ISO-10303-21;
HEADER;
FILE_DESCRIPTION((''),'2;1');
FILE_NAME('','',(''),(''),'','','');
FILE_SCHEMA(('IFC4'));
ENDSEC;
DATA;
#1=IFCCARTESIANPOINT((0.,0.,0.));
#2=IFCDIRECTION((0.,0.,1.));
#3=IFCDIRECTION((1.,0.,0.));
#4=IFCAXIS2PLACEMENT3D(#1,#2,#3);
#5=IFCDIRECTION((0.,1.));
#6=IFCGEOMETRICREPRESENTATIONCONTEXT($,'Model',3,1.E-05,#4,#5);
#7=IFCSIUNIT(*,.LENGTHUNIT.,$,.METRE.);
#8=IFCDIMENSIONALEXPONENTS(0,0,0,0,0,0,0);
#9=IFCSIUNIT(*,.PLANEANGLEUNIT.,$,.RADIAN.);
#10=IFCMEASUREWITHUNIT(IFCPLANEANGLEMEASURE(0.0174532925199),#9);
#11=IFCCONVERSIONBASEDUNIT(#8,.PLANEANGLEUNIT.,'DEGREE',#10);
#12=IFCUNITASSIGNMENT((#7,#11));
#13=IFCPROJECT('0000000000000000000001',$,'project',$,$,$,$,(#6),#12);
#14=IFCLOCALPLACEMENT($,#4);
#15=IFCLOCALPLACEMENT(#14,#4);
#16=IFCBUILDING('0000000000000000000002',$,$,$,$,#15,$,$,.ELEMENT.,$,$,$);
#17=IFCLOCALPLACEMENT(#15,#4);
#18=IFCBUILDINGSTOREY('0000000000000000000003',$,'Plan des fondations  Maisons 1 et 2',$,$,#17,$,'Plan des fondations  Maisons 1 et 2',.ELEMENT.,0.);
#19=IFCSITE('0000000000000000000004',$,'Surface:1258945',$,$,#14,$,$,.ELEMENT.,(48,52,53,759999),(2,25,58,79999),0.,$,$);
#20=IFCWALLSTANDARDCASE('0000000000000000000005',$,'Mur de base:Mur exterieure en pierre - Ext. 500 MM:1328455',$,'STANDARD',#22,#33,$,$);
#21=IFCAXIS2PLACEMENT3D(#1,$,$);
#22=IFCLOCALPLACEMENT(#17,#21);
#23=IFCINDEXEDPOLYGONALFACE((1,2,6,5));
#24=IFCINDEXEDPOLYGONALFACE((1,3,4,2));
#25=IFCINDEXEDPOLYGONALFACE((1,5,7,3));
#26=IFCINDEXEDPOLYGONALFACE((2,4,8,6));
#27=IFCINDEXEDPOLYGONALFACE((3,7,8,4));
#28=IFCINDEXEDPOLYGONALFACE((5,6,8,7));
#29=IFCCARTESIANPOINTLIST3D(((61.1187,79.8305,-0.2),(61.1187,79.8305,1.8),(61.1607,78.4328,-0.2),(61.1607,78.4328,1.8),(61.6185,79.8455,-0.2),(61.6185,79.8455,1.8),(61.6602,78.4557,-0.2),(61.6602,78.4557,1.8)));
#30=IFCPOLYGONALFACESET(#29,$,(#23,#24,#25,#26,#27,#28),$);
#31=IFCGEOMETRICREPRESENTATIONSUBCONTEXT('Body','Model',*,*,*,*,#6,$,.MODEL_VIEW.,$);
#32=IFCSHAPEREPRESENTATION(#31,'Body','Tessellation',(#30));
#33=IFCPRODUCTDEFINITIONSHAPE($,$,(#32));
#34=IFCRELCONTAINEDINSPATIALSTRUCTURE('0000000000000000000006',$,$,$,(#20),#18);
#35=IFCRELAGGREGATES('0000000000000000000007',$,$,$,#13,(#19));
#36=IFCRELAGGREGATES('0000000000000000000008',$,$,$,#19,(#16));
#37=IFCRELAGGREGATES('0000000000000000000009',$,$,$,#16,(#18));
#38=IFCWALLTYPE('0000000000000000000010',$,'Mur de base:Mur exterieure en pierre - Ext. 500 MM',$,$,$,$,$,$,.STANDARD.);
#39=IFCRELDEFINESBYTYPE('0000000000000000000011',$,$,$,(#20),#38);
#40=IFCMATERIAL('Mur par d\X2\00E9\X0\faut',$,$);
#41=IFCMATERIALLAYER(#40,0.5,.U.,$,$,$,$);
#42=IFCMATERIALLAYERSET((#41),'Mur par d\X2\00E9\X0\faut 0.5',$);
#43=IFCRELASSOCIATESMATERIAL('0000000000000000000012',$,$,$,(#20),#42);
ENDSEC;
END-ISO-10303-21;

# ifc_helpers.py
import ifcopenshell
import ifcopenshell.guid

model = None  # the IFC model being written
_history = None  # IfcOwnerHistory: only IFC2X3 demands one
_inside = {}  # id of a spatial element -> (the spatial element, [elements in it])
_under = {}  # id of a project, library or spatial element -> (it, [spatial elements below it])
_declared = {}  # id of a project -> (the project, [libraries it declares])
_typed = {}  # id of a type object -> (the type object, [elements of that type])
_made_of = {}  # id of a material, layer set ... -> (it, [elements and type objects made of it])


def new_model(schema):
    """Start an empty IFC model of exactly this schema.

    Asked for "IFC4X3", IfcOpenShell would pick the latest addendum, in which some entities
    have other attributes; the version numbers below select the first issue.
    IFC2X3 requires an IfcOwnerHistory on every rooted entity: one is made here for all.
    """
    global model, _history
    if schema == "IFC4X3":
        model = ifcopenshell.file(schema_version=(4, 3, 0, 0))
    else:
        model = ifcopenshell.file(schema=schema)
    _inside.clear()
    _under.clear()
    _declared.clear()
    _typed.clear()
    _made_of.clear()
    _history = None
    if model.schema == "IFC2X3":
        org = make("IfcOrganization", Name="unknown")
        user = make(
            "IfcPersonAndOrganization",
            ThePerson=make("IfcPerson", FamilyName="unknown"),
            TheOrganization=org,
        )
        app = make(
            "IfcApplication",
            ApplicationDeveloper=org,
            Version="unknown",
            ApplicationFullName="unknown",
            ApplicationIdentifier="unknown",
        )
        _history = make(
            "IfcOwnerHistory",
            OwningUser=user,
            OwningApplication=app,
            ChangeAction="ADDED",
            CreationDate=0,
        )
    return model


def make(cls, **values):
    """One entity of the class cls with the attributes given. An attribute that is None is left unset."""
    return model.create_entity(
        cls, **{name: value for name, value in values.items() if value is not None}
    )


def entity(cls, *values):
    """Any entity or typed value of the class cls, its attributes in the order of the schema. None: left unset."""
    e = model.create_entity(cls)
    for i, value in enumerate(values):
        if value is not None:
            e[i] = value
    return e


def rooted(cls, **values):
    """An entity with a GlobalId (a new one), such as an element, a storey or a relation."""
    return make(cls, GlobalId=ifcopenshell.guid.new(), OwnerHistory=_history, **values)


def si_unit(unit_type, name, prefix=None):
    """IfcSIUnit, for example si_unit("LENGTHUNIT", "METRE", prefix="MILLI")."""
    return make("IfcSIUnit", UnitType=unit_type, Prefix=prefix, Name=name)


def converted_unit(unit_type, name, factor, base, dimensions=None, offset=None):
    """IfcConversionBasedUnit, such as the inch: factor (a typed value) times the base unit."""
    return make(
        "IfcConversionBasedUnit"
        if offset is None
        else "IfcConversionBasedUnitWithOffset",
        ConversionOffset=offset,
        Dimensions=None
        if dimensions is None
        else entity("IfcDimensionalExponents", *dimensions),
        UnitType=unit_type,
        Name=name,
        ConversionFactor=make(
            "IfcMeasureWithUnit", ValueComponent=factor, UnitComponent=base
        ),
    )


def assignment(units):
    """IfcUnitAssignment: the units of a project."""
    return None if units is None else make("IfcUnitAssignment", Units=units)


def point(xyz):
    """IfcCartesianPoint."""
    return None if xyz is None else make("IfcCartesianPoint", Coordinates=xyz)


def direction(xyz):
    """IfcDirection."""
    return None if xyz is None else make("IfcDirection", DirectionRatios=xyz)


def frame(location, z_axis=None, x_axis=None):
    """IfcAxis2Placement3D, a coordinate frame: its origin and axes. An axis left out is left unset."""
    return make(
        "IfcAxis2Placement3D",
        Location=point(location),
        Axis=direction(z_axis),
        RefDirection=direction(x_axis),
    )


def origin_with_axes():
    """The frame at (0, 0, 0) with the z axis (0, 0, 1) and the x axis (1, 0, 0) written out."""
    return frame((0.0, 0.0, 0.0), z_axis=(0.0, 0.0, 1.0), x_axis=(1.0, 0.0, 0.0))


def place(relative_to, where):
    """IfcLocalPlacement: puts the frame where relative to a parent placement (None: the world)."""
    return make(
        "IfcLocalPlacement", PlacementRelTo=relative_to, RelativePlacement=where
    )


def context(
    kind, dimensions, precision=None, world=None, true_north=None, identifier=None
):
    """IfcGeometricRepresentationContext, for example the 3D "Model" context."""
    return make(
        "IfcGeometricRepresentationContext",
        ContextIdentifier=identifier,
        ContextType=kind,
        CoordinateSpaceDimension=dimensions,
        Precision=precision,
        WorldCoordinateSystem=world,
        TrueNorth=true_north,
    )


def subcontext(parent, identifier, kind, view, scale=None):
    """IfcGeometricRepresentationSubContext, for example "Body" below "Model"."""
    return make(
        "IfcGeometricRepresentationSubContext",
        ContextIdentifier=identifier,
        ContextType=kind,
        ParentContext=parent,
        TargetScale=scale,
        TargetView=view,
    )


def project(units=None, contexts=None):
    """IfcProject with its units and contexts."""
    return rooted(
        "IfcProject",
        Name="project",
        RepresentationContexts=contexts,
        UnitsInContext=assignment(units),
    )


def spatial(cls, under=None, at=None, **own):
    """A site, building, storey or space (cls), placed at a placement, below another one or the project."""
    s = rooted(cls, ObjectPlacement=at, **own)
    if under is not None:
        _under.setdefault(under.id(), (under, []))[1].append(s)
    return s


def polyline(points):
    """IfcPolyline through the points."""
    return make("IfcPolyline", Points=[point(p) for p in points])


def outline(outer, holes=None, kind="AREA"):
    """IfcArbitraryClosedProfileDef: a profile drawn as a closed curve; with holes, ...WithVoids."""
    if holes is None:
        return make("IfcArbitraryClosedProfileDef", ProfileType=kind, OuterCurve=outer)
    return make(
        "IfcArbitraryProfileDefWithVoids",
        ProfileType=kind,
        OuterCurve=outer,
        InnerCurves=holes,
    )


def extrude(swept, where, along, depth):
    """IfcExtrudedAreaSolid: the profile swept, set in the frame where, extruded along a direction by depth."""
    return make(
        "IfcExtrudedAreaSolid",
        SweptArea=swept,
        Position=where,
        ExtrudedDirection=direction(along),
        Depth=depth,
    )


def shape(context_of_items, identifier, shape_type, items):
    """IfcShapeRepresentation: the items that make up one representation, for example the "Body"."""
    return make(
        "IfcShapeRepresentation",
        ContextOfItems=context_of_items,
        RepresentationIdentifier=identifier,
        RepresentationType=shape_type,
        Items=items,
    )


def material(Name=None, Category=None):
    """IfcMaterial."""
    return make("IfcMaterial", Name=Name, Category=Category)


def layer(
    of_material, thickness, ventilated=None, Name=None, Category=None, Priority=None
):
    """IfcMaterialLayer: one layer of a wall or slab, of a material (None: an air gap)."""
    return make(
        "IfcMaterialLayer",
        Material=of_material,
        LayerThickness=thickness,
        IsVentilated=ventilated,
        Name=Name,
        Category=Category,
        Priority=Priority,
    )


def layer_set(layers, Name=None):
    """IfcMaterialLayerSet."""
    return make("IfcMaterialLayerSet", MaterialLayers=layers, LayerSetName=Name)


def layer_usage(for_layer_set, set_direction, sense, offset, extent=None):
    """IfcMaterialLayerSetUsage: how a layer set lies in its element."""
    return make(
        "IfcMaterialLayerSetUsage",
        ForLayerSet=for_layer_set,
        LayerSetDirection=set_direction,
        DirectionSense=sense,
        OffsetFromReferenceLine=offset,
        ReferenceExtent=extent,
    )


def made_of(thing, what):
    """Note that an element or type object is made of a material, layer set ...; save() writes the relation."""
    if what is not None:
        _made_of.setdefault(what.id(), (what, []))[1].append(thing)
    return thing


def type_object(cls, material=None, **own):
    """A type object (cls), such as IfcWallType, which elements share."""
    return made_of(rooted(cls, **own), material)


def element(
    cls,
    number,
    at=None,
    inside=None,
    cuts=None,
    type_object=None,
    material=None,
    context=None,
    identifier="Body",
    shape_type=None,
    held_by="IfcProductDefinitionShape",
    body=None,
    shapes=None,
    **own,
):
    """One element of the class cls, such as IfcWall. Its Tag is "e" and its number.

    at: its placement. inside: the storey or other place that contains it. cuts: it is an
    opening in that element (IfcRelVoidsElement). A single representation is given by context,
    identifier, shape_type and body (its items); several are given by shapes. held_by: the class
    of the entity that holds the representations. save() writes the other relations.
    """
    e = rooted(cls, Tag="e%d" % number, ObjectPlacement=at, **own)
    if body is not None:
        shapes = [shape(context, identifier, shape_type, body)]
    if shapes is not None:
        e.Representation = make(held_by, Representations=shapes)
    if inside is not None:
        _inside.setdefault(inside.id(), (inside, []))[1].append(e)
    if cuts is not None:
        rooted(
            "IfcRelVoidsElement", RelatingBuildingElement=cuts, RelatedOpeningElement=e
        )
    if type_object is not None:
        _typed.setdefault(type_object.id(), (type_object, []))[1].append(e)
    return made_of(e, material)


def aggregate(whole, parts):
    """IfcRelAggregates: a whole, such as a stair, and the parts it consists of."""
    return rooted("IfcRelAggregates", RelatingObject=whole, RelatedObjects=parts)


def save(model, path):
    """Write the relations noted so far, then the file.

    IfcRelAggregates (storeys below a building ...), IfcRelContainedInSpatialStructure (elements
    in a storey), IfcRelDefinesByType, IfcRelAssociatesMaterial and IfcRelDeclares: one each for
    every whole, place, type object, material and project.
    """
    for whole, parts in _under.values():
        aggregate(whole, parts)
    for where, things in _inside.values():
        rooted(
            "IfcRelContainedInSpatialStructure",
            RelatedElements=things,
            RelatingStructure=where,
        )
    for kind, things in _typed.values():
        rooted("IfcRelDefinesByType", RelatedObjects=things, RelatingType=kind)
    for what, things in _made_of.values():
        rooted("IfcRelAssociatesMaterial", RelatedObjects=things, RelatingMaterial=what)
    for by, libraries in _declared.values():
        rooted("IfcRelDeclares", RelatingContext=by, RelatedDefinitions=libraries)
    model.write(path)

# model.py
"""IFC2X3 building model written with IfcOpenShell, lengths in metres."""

from ifc_helpers import new_model, entity, si_unit, converted_unit, direction, frame, origin_with_axes, place, context, subcontext, project, spatial, polyline, outline, extrude, material, layer, layer_set, layer_usage, type_object, element, save


model = new_model("IFC2X3")

# Units and contexts
model_context = context("Model", 3, precision=1e-05, world=origin_with_axes(), true_north=direction((0.0, 1.0)))
body_context = subcontext(model_context, "Body", "Model", "MODEL_VIEW")
ifc_project = project(units=[si_unit("LENGTHUNIT", "METRE"), converted_unit("PLANEANGLEUNIT", "DEGREE", entity("IfcPlaneAngleMeasure", 0.0174532925199), si_unit("PLANEANGLEUNIT", "RADIAN"), dimensions=[0, 0, 0, 0, 0, 0, 0])], contexts=[model_context])

# Site, building, storey
site_placement = place(None, origin_with_axes())
site = spatial("IfcSite", under=ifc_project, at=site_placement, Name="Surface:1258945", CompositionType="ELEMENT", RefLatitude=(48, 52, 53, 759999), RefLongitude=(2, 25, 58, 79999), RefElevation=0.0)
building_placement = place(site_placement, origin_with_axes())
building = spatial("IfcBuilding", under=site, at=building_placement, CompositionType="ELEMENT")
storey_placement = place(building_placement, origin_with_axes())
storey = spatial("IfcBuildingStorey", under=building, at=storey_placement, Name="Plan des fondations  Maisons 1 et 2", LongName="Plan des fondations  Maisons 1 et 2", CompositionType="ELEMENT", Elevation=0.0)

# Wall
ifc_material_1 = material(Name="Mur par défaut")
ifc_layer_1 = layer(ifc_material_1, 0.5, ventilated="UNKNOWN")
ifc_layer_set_1 = layer_set([ifc_layer_1], Name="Mur par défaut 0.5")
wall_type_1 = type_object("IfcWallType", Name="Mur de base:Mur exterieure en pierre - Ext. 500 MM", PredefinedType="STANDARD")
ifc_layer_usage_1 = layer_usage(ifc_layer_set_1, "AXIS2", "POSITIVE", -0.25)
wall_1_placement = place(storey_placement, frame((61.3686, 79.838, -0.2), z_axis=(0.0, 0.0, 1.0), x_axis=(0.030044, -0.999549, 0.0)))
element("IfcWallStandardCase", 1, at=wall_1_placement, inside=storey, type_object=wall_type_1, material=ifc_layer_usage_1, Name="Mur de base:Mur exterieure en pierre - Ext. 500 MM:1328455", ObjectType="STANDARD", context=body_context, shape_type="SweptSolid", body=[
    extrude(outline(polyline([(0.0, -0.25), (1.3984, -0.25), (1.3905, 0.25), (0.0, 0.25), (0.0, -0.25)])), origin_with_axes(), (0.0, 0.0, 1.0), 2.0),
])

save(model, "model.ifc")
